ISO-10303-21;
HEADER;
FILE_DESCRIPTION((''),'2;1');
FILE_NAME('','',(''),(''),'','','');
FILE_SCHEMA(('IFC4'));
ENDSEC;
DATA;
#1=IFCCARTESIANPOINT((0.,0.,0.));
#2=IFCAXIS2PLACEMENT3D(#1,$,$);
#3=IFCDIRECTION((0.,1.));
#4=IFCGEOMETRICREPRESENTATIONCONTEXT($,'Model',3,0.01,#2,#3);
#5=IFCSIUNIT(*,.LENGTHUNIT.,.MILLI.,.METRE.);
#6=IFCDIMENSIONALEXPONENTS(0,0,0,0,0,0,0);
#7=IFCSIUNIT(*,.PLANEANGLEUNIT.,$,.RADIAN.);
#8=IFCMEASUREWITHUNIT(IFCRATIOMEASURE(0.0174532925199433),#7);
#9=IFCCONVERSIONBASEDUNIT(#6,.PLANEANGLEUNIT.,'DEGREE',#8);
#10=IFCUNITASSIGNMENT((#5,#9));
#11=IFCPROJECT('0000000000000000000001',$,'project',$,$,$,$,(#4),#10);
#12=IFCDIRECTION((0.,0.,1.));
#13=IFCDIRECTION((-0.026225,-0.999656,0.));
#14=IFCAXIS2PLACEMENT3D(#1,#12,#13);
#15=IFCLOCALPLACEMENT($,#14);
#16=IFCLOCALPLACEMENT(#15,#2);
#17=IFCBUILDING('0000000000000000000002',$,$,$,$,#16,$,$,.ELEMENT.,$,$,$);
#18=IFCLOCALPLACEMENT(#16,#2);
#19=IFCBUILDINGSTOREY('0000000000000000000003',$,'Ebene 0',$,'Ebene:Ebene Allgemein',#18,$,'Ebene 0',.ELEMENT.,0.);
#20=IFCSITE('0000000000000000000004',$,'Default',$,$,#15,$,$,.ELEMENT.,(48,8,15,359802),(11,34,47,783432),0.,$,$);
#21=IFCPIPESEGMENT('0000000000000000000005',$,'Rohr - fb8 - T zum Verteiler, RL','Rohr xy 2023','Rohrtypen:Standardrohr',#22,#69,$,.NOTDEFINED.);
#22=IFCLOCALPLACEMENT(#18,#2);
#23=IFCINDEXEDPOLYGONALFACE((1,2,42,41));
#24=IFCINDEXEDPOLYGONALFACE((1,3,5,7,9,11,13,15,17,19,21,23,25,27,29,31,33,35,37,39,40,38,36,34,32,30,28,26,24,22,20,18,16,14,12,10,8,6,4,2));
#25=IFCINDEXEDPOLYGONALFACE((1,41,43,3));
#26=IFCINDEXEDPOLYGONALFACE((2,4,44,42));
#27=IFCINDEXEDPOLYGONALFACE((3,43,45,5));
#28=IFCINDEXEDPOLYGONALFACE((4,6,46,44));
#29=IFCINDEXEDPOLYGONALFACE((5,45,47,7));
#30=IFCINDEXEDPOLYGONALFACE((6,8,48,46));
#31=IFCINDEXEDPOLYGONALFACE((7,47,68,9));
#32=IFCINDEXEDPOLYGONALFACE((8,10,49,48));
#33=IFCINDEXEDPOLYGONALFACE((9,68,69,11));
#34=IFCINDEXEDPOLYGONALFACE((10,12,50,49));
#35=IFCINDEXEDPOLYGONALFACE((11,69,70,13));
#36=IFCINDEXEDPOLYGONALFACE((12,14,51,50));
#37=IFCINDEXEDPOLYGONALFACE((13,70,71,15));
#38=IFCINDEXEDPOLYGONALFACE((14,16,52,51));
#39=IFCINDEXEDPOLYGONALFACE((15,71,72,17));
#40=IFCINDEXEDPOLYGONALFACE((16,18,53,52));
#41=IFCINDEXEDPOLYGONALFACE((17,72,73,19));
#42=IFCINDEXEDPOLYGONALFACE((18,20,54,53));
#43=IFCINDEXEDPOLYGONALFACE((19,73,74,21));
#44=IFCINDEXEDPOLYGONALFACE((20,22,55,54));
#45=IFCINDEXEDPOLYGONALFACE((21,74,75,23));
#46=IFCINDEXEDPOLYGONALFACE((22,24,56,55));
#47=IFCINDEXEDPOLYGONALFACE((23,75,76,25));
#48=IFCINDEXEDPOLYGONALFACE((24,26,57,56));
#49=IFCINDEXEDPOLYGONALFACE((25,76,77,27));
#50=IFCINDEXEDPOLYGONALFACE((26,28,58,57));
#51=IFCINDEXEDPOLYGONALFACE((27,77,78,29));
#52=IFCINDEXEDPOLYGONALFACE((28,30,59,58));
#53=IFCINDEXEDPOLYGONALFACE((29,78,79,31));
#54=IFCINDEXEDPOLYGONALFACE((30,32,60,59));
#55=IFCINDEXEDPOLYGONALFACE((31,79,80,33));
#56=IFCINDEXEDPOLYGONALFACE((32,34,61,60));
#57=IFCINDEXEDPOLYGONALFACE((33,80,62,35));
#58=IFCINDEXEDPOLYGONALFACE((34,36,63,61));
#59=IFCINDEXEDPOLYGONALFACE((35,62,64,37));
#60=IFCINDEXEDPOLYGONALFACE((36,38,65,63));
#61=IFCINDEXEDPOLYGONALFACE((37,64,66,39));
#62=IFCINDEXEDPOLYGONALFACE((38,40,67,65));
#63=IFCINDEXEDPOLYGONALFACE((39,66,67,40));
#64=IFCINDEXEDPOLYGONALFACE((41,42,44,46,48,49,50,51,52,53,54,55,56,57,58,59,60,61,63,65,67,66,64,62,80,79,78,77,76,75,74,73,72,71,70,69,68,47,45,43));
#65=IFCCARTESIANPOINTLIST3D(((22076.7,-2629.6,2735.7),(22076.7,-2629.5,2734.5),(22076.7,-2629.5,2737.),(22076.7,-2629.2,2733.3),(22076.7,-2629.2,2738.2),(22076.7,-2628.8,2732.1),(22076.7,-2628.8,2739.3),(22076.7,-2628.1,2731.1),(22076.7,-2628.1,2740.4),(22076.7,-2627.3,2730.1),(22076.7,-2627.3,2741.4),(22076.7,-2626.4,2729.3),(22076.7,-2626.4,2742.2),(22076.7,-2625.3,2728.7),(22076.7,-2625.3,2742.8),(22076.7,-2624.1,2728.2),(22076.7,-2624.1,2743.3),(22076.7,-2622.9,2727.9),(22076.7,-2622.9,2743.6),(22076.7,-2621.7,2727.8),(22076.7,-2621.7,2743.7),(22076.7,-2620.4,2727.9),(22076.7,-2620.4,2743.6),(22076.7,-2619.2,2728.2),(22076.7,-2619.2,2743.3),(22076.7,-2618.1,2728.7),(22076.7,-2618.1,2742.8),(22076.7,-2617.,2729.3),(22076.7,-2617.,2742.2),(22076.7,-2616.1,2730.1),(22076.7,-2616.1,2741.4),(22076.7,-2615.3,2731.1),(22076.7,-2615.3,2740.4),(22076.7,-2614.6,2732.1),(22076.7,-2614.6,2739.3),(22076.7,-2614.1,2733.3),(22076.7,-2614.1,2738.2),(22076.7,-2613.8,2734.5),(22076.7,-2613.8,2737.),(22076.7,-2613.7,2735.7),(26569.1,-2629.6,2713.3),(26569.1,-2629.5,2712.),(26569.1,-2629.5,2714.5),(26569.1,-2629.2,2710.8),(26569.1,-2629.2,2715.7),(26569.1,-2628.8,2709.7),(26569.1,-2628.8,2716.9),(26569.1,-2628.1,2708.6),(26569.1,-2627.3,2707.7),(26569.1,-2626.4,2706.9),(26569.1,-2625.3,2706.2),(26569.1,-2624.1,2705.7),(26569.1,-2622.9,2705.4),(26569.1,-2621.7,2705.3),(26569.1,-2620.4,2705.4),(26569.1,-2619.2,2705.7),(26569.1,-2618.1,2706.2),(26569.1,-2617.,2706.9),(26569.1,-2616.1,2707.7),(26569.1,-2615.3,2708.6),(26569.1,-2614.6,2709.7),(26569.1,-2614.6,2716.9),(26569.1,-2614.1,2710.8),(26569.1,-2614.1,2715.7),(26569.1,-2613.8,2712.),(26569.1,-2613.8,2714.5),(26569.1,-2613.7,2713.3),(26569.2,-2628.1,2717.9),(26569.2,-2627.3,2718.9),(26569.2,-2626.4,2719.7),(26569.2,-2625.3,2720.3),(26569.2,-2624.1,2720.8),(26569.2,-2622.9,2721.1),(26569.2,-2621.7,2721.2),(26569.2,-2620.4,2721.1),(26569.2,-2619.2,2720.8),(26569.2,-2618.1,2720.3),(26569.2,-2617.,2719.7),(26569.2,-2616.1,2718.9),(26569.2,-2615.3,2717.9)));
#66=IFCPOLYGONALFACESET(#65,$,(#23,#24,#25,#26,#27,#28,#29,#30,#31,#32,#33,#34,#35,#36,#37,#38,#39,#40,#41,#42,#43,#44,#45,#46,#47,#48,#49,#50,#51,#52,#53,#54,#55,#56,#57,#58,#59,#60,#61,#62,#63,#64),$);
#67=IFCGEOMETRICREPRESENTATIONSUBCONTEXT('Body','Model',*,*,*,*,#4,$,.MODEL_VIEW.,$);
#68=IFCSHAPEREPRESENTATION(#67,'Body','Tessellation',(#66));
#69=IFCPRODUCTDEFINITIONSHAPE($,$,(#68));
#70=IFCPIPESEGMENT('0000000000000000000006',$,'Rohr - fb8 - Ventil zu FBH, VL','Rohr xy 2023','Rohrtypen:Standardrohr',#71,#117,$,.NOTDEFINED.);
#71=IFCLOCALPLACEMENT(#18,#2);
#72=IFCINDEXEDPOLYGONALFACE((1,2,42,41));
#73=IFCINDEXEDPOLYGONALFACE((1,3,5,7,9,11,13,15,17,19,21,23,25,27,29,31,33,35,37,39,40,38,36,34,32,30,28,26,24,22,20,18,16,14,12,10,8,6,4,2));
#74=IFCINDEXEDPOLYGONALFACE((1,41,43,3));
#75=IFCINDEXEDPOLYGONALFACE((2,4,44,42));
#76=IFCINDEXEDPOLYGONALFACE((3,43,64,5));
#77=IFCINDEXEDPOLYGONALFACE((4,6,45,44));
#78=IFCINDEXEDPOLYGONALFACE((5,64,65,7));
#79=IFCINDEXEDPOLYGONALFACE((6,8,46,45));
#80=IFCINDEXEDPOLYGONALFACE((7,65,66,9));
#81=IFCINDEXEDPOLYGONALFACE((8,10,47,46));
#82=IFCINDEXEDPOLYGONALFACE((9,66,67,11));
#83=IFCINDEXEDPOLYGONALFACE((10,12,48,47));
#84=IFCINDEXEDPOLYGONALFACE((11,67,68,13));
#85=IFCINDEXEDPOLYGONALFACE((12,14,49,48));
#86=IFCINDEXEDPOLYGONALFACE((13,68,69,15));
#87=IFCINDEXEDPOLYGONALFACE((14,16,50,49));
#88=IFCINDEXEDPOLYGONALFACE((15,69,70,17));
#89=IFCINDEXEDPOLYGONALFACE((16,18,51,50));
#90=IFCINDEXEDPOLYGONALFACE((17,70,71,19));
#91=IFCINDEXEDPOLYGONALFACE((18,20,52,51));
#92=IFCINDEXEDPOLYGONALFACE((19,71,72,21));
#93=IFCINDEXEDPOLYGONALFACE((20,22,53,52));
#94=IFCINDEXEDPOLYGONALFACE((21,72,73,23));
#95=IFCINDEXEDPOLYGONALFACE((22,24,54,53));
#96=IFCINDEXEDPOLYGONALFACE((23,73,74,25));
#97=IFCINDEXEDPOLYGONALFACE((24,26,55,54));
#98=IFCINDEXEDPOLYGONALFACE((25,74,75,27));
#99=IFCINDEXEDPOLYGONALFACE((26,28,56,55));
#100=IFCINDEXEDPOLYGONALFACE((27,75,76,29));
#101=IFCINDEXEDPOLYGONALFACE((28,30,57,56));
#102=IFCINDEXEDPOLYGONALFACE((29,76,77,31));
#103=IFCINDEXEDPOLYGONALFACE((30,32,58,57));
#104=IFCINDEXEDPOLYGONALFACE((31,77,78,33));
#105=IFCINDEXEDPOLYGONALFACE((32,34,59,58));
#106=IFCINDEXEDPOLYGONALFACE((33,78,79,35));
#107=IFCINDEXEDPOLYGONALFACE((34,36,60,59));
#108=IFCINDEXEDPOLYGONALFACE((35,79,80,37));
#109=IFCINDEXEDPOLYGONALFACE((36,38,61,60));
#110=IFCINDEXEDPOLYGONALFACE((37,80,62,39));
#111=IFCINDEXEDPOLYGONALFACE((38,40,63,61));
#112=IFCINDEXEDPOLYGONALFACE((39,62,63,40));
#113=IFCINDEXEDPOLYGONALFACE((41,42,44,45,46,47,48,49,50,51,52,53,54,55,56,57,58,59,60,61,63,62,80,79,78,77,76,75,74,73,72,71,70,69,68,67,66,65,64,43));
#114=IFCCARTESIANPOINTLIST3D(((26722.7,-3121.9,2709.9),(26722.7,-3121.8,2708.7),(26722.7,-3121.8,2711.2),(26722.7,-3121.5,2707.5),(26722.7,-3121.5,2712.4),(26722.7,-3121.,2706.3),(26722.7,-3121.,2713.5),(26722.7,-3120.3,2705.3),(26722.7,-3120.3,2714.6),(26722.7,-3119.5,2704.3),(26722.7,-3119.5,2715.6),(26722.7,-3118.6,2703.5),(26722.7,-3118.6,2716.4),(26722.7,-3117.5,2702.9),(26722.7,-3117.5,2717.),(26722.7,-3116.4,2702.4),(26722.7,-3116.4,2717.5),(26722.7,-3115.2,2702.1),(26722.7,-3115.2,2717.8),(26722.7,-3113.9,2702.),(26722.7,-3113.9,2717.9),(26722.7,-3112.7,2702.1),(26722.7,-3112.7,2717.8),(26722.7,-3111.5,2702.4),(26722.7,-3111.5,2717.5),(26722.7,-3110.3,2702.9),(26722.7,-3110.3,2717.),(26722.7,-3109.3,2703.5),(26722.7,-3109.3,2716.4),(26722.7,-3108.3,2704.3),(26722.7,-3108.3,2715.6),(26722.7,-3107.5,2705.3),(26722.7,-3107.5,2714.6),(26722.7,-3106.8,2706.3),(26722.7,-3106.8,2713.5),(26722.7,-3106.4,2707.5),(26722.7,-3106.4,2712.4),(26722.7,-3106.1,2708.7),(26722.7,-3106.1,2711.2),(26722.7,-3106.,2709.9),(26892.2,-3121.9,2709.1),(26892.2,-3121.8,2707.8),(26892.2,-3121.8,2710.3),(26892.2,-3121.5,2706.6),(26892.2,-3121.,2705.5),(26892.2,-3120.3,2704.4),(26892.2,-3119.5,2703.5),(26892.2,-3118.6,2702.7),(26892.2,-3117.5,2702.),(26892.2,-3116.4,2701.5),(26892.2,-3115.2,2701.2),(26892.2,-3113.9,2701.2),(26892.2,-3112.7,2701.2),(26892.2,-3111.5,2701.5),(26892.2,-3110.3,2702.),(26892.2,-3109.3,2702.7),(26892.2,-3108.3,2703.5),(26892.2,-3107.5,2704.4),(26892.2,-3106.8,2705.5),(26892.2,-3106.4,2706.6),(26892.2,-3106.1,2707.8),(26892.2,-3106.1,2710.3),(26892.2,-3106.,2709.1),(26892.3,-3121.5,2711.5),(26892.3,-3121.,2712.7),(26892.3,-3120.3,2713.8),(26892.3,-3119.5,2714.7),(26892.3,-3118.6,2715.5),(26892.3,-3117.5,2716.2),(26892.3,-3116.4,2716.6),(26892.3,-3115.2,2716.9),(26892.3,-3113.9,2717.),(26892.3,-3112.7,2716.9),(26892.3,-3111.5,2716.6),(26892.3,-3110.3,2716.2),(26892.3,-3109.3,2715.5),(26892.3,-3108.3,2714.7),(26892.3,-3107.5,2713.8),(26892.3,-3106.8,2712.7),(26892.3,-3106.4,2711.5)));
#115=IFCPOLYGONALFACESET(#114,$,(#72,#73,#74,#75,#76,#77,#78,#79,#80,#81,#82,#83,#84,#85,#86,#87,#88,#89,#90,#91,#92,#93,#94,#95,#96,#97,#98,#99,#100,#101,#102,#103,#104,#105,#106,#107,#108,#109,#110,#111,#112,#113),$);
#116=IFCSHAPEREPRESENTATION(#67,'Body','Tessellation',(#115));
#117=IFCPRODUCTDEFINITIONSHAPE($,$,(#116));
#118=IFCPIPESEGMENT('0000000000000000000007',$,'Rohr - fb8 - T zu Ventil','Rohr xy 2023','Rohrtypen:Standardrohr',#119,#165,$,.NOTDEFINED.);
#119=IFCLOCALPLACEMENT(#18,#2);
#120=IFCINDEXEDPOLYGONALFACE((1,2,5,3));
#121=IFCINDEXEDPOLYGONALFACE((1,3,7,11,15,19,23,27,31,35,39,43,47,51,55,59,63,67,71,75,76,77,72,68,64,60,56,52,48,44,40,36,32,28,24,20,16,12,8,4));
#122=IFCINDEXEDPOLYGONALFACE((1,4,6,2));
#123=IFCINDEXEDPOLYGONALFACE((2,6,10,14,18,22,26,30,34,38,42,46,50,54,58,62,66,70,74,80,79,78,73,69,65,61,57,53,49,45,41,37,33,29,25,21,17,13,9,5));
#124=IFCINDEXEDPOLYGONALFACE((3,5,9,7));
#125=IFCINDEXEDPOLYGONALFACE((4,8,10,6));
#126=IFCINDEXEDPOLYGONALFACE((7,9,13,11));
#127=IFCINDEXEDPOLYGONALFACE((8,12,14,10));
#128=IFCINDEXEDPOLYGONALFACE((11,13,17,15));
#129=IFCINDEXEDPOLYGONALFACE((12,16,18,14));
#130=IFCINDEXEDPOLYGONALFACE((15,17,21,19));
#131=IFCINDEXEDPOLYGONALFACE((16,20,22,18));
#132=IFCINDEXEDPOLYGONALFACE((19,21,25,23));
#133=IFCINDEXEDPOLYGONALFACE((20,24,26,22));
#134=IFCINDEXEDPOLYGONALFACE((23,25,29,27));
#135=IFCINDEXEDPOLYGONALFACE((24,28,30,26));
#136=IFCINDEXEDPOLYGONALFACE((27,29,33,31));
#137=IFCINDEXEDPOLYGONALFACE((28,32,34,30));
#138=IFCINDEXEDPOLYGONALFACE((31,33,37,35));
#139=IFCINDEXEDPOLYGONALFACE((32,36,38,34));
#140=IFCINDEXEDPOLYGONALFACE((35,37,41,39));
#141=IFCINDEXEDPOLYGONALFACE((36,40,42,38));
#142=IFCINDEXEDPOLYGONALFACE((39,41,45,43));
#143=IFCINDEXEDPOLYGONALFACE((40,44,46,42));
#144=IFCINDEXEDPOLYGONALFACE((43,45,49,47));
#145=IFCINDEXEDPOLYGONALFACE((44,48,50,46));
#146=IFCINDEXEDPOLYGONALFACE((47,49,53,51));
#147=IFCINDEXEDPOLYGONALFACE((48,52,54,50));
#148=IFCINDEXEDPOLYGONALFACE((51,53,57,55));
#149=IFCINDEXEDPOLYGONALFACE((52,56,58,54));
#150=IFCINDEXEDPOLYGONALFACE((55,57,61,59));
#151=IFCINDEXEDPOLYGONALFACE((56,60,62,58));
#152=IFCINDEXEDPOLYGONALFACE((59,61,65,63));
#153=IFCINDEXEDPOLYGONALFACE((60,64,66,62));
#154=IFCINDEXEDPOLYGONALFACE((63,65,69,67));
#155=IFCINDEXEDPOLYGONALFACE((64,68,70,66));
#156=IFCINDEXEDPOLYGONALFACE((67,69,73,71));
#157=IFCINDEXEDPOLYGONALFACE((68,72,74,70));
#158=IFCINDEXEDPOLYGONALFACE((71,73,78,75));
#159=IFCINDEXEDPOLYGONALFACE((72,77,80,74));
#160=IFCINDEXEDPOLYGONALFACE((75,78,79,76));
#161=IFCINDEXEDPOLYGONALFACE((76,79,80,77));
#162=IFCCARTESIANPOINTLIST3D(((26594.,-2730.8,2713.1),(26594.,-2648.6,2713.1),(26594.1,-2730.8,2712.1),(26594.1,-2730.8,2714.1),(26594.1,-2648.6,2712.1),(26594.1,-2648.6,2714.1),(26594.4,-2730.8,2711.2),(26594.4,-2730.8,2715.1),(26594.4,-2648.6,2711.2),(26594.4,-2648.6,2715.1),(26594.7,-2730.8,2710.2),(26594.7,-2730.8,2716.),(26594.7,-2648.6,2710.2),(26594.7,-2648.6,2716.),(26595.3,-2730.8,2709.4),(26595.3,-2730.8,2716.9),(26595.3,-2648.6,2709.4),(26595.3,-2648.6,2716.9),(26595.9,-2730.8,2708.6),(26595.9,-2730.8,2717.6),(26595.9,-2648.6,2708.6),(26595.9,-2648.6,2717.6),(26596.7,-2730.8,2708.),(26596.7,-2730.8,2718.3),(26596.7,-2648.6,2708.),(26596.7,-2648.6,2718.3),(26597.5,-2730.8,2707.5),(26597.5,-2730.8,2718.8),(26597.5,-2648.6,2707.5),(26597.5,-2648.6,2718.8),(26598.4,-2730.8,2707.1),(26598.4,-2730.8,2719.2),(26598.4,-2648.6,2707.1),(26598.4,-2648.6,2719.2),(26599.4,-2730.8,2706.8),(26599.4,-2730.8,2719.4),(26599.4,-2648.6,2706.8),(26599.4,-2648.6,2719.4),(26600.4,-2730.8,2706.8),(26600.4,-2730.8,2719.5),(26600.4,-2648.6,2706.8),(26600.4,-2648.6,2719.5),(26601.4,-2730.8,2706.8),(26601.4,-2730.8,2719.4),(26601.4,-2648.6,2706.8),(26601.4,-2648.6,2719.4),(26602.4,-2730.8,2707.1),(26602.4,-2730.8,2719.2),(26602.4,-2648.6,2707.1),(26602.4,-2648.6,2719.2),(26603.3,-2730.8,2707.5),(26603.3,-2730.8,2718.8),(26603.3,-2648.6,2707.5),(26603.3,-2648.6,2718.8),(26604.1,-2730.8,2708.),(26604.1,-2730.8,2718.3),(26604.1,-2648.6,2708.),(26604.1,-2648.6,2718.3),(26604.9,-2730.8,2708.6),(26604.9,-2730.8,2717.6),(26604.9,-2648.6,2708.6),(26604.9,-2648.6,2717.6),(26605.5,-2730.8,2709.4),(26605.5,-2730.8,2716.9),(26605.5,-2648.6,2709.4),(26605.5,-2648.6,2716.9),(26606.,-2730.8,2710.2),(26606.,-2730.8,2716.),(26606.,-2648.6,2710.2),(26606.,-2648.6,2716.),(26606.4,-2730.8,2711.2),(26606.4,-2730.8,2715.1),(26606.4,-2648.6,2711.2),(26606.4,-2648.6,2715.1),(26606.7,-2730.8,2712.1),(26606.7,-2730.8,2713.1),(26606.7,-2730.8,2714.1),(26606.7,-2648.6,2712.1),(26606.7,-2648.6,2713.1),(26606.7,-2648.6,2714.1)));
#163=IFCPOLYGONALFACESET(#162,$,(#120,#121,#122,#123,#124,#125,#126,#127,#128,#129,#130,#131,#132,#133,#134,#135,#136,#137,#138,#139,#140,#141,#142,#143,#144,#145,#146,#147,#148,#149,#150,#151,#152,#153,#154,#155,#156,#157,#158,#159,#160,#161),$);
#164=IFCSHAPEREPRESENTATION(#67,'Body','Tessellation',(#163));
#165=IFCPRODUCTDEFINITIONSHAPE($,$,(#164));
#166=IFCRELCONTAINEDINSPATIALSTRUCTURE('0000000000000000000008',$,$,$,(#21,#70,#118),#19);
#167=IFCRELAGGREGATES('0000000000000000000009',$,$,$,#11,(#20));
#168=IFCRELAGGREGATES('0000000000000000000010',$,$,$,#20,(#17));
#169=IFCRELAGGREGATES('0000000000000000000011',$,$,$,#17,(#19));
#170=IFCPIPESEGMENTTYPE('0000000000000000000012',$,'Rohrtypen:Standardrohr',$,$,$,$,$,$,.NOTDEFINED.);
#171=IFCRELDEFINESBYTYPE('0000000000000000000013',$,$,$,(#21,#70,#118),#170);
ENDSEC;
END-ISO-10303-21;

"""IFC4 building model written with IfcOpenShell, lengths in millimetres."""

from ifc_helpers import new_model, entity, si_unit, converted_unit, direction, frame, origin, place, context, subcontext, project, spatial, indexed_curve, outline, extrude, type_object, element, save


model = new_model("IFC4")

# Units and contexts
model_context = context("Model", 3, precision=0.01, world=origin(), true_north=direction((0.0, 1.0)))
body_context = subcontext(model_context, "Body", "Model", "MODEL_VIEW")
ifc_project = project(units=[si_unit("LENGTHUNIT", "METRE", prefix="MILLI"), converted_unit("PLANEANGLEUNIT", "DEGREE", entity("IfcRatioMeasure", 0.0174532925199433), si_unit("PLANEANGLEUNIT", "RADIAN"), dimensions=[0, 0, 0, 0, 0, 0, 0])], contexts=[model_context])

# Site, building, storey
site_placement = place(None, frame((0.0, 0.0, 0.0), z_axis=(0.0, 0.0, 1.0), x_axis=(-0.026225, -0.999656, 0.0)))
site = spatial("IfcSite", under=ifc_project, at=site_placement, Name="Default", CompositionType="ELEMENT", RefLatitude=(48, 8, 15, 359802), RefLongitude=(11, 34, 47, 783432), RefElevation=0.0)
building_placement = place(site_placement, origin())
building = spatial("IfcBuilding", under=site, at=building_placement, CompositionType="ELEMENT")
storey_placement = place(building_placement, origin())
storey = spatial("IfcBuildingStorey", under=building, at=storey_placement, Name="Ebene 0", ObjectType="Ebene:Ebene Allgemein", LongName="Ebene 0", CompositionType="ELEMENT", Elevation=0.0)

# Pipe segments
pipe_segment_type = type_object("IfcPipeSegmentType", Name="Rohrtypen:Standardrohr", PredefinedType="NOTDEFINED")
pipe_segment_1_placement = place(storey_placement, origin())
element("IfcPipeSegment", 1, at=pipe_segment_1_placement, inside=storey, type_object=pipe_segment_type, Name="Rohr - fb8 - T zum Verteiler, RL", Description="Rohr xy 2023", ObjectType="Rohrtypen:Standardrohr", PredefinedType="NOTDEFINED", context=body_context, shape_type="SweptSolid", body=[
    extrude(outline(indexed_curve([(7.9, 0.0), (7.8, 1.2), (7.6, 2.5), (7.1, 3.6), (6.4, 4.7), (5.6, 5.6), (4.7, 6.4), (3.6, 7.1), (2.5, 7.6), (1.2, 7.8), (0.0, 7.9), (-1.2, 7.8), (-2.5, 7.6), (-3.6, 7.1), (-4.7, 6.4), (-5.6, 5.6), (-6.4, 4.7), (-7.1, 3.6), (-7.6, 2.5), (-7.8, 1.2), (-7.9, 0.0), (-7.8, -1.2), (-7.6, -2.5), (-7.1, -3.6), (-6.4, -4.7), (-5.6, -5.6), (-4.7, -6.4), (-3.6, -7.1), (-2.5, -7.6), (-1.2, -7.8), (0.0, -7.9), (1.2, -7.8), (2.5, -7.6), (3.6, -7.1), (4.7, -6.4), (5.6, -5.6), (6.4, -4.7), (7.1, -3.6), (7.6, -2.5), (7.8, -1.2), (7.9, 0.0)], self_intersect=False)), frame((26569.1, -2621.7, 2713.3), z_axis=(-0.999988, 0.0, 0.005), x_axis=(0.0, 1.0, 0.0)), (0.0, 0.0, 1.0), 4492.5),
])
pipe_segment_2_placement = place(storey_placement, origin())
element("IfcPipeSegment", 2, at=pipe_segment_2_placement, inside=storey, type_object=pipe_segment_type, Name="Rohr - fb8 - Ventil zu FBH, VL", Description="Rohr xy 2023", ObjectType="Rohrtypen:Standardrohr", PredefinedType="NOTDEFINED", context=body_context, shape_type="SweptSolid", body=[
    extrude(outline(indexed_curve([(7.9, 0.0), (7.8, 1.2), (7.6, 2.5), (7.1, 3.6), (6.4, 4.7), (5.6, 5.6), (4.7, 6.4), (3.6, 7.1), (2.5, 7.6), (1.2, 7.8), (0.0, 7.9), (-1.2, 7.8), (-2.5, 7.6), (-3.6, 7.1), (-4.7, 6.4), (-5.6, 5.6), (-6.4, 4.7), (-7.1, 3.6), (-7.6, 2.5), (-7.8, 1.2), (-7.9, 0.0), (-7.8, -1.2), (-7.6, -2.5), (-7.1, -3.6), (-6.4, -4.7), (-5.6, -5.6), (-4.7, -6.4), (-3.6, -7.1), (-2.5, -7.6), (-1.2, -7.8), (0.0, -7.9), (1.2, -7.8), (2.5, -7.6), (3.6, -7.1), (4.7, -6.4), (5.6, -5.6), (6.4, -4.7), (7.1, -3.6), (7.6, -2.5), (7.8, -1.2), (7.9, 0.0)], self_intersect=False)), frame((26722.7, -3113.9, 2709.9), z_axis=(0.999988, 0.0, -0.005), x_axis=(0.0, 1.0, 0.0)), (0.0, 0.0, 1.0), 169.5),
])
pipe_segment_3_placement = place(storey_placement, origin())
element("IfcPipeSegment", 3, at=pipe_segment_3_placement, inside=storey, type_object=pipe_segment_type, Name="Rohr - fb8 - T zu Ventil", Description="Rohr xy 2023", ObjectType="Rohrtypen:Standardrohr", PredefinedType="NOTDEFINED", context=body_context, shape_type="SweptSolid", body=[
    extrude(outline(indexed_curve([(6.3, 0.0), (6.3, 1.0), (6.0, 2.0), (5.7, 2.9), (5.1, 3.7), (4.5, 4.5), (3.7, 5.1), (2.9, 5.7), (2.0, 6.0), (1.0, 6.3), (0.0, 6.4), (-1.0, 6.3), (-2.0, 6.0), (-2.9, 5.7), (-3.7, 5.1), (-4.5, 4.5), (-5.1, 3.7), (-5.7, 2.9), (-6.0, 2.0), (-6.3, 1.0), (-6.4, 0.0), (-6.3, -1.0), (-6.0, -2.0), (-5.7, -2.9), (-5.1, -3.7), (-4.5, -4.5), (-3.7, -5.1), (-2.9, -5.7), (-2.0, -6.0), (-1.0, -6.3), (0.0, -6.4), (1.0, -6.3), (2.0, -6.0), (2.9, -5.7), (3.7, -5.1), (4.5, -4.5), (5.1, -3.7), (5.7, -2.9), (6.0, -2.0), (6.3, -1.0), (6.3, 0.0)], self_intersect=False)), frame((26600.4, -2730.8, 2713.1), z_axis=(0.0, 1.0, 0.0), x_axis=(-1.0, 0.0, 0.0)), (0.0, 0.0, 1.0), 82.2),
])

save(model, "model.ifc")
